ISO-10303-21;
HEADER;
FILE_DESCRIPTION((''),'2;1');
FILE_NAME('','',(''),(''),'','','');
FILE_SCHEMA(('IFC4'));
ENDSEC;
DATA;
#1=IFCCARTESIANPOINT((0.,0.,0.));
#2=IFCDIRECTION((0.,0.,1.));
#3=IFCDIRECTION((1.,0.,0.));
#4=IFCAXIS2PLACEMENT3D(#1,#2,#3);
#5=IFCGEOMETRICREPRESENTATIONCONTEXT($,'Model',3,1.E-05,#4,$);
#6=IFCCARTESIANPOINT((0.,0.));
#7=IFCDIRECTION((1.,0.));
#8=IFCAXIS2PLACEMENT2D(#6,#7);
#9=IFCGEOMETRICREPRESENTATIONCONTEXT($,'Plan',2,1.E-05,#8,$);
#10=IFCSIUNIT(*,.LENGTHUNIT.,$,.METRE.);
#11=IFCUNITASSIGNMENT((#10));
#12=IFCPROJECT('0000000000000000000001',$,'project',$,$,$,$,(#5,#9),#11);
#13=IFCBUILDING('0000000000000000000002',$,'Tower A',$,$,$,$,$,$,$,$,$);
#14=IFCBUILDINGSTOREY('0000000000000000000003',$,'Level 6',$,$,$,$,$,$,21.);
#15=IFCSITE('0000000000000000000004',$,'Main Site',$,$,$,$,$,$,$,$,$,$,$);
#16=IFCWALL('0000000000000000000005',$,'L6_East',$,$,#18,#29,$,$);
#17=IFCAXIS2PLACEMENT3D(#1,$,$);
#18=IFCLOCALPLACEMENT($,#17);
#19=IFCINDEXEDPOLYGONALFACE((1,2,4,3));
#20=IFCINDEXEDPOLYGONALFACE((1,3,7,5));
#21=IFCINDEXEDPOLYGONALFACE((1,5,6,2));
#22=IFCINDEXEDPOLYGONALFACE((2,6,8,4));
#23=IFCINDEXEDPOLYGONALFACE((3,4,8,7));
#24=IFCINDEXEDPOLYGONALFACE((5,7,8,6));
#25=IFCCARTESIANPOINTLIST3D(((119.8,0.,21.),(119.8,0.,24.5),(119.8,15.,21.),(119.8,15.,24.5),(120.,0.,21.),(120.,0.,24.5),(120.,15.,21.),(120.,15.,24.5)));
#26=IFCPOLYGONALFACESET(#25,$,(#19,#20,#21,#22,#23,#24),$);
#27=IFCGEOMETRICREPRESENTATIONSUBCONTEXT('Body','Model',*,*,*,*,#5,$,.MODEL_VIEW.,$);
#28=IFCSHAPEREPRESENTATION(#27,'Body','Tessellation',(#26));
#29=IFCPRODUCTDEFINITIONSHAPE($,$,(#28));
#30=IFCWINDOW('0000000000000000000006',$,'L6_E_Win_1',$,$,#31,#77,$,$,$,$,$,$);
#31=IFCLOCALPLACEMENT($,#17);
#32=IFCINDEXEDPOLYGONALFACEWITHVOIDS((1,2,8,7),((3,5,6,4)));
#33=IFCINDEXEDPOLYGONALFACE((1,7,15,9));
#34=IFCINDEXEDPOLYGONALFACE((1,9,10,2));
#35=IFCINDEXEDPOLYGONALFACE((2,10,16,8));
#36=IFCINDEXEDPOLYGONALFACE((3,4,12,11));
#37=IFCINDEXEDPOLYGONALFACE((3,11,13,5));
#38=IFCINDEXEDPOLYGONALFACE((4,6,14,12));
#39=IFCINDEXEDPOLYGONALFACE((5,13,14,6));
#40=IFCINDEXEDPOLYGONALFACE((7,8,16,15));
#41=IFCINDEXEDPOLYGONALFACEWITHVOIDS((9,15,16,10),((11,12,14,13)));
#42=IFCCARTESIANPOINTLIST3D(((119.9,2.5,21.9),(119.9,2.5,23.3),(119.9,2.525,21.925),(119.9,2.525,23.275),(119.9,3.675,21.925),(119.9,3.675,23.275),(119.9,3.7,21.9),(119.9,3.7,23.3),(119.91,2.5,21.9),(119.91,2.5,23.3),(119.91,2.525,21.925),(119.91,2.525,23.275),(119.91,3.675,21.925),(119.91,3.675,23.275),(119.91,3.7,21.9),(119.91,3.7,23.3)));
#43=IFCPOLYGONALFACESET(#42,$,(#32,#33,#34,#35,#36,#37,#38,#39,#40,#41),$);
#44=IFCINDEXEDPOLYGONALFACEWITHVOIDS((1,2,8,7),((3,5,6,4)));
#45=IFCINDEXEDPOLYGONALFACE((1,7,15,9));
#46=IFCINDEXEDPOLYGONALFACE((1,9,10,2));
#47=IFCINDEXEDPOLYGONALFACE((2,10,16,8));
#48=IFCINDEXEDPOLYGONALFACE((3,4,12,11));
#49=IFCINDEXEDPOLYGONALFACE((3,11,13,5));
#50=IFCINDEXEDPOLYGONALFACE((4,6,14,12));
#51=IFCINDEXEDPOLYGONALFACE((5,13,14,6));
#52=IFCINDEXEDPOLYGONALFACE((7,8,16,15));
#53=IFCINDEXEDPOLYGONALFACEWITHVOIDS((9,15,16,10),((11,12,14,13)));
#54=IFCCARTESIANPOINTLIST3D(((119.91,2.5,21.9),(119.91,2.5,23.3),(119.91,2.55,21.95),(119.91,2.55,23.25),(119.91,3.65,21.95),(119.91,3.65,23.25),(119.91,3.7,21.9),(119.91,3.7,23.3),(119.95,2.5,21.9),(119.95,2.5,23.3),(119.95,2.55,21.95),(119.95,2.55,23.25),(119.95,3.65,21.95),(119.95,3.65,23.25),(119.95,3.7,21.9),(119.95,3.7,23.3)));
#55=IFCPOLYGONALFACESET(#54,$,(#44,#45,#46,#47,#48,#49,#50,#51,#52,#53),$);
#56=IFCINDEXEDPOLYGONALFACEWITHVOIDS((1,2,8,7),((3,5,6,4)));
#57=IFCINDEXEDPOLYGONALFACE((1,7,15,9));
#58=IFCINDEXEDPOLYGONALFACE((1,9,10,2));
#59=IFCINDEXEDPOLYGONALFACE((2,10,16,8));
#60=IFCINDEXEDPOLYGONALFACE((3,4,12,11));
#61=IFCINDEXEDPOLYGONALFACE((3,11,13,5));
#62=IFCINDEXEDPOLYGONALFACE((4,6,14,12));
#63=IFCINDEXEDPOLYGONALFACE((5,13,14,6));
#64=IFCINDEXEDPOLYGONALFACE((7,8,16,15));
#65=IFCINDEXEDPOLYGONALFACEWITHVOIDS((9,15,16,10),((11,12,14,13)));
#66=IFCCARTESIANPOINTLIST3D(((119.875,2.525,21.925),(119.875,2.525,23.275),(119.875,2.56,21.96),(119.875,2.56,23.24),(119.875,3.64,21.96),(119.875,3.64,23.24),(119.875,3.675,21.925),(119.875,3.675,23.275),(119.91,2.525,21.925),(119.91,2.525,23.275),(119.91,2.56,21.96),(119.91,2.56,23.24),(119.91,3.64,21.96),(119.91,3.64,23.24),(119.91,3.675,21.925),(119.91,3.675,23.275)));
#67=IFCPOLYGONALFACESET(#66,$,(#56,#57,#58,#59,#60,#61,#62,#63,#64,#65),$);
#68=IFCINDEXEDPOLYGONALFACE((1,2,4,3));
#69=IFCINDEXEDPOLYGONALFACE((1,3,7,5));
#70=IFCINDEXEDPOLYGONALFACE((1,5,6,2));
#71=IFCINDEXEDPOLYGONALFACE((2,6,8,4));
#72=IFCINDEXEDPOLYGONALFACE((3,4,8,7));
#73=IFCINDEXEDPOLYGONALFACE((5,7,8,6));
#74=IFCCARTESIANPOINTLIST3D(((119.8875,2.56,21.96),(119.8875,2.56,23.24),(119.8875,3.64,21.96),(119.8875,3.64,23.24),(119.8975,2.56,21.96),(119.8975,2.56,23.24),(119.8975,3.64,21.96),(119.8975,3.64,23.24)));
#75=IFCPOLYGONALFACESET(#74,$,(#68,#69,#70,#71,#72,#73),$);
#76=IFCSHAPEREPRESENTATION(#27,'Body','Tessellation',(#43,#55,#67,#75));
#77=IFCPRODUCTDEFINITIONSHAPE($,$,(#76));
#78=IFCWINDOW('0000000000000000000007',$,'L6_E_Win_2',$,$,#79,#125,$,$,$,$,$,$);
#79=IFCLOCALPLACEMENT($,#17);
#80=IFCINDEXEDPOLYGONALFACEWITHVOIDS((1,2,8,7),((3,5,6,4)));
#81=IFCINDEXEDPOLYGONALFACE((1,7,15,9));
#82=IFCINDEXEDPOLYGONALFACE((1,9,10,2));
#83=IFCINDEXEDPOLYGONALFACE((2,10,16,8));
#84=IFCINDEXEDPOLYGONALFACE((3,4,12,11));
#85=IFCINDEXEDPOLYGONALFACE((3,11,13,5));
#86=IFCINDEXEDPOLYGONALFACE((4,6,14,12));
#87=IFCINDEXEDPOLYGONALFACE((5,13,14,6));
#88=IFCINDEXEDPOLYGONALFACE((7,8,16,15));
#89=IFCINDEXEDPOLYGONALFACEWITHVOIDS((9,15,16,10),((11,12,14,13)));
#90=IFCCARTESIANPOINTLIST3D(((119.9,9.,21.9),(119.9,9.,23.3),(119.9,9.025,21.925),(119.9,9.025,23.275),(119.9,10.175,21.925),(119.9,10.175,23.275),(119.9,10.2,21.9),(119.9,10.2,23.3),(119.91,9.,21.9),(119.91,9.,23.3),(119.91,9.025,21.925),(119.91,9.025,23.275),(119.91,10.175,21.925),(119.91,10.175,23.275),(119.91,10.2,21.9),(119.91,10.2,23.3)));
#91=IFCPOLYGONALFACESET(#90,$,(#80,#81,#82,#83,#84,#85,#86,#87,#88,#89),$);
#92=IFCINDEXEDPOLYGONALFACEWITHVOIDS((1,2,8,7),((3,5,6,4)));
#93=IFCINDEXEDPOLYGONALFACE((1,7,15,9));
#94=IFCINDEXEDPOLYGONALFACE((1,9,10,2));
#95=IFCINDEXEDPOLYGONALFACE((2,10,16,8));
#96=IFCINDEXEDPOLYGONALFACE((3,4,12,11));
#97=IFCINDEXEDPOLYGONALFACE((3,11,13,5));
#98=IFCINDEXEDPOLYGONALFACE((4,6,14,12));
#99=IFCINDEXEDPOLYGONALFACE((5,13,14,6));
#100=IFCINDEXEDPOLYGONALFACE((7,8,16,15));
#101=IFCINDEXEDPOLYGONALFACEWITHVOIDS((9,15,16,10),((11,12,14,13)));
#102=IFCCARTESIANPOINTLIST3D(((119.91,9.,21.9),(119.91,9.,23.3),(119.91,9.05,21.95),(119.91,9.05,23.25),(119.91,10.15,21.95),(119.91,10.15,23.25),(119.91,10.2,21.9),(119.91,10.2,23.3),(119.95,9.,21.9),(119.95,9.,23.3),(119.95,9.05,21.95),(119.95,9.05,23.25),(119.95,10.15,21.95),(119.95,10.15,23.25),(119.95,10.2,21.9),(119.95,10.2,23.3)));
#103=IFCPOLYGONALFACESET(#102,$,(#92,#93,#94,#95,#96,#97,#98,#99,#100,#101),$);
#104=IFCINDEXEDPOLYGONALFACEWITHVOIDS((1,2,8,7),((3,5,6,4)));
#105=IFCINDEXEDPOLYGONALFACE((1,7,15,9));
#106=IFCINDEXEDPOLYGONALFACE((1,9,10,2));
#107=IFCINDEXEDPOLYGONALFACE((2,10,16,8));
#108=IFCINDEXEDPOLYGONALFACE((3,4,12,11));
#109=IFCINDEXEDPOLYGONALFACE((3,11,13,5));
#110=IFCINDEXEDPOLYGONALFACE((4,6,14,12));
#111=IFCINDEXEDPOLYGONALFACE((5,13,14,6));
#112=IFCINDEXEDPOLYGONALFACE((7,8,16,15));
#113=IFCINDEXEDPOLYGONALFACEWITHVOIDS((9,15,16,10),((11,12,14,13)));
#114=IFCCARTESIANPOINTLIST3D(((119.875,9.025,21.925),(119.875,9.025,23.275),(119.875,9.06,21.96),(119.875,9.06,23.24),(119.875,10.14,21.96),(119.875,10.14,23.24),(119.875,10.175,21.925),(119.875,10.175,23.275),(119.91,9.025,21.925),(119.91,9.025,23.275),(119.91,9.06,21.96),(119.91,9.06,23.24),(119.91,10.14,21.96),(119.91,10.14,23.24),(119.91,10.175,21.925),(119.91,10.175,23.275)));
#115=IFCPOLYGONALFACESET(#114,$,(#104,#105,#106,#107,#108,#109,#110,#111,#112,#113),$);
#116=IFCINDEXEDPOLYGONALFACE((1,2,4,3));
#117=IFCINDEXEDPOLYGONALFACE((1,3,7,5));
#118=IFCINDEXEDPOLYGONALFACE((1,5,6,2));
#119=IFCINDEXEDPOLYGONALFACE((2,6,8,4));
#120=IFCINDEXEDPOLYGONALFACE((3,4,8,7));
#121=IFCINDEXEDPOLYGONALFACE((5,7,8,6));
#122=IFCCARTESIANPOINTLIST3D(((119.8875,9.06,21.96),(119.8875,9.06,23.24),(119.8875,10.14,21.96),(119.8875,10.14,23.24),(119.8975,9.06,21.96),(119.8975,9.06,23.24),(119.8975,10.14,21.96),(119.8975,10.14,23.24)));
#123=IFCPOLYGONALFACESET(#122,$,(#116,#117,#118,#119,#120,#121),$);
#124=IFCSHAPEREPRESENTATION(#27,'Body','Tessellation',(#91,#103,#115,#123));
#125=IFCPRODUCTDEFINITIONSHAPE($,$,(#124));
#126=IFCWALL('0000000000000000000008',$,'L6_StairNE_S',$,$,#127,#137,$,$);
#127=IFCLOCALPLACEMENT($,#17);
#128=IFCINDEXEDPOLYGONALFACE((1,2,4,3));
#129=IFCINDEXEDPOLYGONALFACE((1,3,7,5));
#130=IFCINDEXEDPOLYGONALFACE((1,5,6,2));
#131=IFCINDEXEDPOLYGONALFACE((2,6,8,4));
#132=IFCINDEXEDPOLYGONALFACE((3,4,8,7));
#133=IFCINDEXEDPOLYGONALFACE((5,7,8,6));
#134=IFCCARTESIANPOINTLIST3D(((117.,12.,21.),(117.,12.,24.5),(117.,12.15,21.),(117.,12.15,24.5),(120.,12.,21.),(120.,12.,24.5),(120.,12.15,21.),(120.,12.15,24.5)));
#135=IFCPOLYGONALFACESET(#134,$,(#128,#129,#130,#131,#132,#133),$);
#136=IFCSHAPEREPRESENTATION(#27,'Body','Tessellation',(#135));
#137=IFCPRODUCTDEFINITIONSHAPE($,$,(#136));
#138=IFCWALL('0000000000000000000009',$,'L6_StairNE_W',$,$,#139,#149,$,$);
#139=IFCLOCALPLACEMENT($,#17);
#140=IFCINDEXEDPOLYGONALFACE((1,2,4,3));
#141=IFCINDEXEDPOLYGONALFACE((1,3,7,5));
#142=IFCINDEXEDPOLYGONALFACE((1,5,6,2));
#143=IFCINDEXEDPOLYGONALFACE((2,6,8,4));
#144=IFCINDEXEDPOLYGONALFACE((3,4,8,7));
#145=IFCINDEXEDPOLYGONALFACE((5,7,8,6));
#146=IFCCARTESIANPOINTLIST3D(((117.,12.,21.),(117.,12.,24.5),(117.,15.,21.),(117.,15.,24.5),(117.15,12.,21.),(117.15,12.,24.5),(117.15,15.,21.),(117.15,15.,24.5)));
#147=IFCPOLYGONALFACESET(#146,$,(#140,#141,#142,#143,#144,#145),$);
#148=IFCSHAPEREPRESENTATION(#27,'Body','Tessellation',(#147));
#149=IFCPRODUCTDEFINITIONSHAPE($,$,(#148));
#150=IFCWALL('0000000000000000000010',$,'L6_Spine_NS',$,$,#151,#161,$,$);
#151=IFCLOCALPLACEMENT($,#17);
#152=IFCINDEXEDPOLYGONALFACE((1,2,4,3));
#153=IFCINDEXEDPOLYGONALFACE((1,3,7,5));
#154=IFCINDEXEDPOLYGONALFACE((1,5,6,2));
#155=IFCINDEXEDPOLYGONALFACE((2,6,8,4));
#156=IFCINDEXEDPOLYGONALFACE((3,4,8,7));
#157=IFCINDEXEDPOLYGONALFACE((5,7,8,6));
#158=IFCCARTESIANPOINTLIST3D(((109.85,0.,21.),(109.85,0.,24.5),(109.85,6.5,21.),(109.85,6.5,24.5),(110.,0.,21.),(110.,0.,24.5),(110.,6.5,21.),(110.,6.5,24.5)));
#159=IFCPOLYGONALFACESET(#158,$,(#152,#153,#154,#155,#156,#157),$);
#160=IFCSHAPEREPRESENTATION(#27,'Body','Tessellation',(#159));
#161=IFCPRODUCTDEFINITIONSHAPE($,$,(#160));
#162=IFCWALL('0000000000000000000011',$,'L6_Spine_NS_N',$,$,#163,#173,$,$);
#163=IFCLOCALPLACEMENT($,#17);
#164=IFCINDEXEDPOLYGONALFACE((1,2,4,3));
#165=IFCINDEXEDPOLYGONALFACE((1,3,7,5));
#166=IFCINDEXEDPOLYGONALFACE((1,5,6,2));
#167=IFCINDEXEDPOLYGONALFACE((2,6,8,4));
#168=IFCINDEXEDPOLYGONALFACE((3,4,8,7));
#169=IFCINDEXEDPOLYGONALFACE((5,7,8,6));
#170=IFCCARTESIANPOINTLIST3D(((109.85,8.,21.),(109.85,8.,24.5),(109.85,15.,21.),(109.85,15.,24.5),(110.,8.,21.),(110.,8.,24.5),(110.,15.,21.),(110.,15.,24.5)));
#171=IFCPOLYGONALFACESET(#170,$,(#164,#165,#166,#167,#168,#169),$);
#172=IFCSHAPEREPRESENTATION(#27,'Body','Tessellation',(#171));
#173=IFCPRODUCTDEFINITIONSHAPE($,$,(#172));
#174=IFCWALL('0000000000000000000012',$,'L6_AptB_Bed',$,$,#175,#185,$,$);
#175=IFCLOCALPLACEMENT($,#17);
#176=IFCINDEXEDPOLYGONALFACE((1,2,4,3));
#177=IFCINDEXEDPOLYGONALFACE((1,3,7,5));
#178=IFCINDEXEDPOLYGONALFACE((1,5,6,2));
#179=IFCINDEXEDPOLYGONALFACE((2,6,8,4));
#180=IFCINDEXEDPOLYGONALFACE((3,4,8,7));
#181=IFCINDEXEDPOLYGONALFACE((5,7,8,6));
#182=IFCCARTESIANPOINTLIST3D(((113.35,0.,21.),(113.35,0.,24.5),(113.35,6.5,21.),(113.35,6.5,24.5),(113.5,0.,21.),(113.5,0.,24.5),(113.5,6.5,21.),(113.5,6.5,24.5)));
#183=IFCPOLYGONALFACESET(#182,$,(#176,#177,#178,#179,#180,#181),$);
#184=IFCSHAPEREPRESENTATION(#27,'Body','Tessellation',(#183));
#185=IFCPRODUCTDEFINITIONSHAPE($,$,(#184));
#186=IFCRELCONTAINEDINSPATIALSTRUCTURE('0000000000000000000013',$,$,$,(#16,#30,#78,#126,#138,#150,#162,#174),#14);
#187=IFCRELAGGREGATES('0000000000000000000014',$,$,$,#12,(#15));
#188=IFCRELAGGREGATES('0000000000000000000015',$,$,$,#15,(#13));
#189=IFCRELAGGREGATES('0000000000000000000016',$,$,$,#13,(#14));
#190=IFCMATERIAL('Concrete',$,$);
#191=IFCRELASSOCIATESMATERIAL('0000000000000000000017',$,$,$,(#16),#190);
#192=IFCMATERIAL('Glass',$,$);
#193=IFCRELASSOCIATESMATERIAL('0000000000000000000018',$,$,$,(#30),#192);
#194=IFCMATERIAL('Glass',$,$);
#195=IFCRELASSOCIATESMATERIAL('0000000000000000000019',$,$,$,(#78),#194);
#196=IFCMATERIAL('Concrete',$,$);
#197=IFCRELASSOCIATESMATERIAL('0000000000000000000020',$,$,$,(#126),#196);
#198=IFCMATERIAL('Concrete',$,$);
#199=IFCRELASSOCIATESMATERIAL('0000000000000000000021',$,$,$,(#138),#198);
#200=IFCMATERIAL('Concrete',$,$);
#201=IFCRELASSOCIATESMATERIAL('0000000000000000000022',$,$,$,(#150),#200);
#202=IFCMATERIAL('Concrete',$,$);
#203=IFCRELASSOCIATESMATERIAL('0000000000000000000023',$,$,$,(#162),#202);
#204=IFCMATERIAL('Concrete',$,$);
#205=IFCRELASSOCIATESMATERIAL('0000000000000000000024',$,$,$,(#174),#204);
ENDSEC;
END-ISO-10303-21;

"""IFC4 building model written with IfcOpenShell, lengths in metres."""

from ifc_helpers import new_model, si_unit, frame, origin_with_axes, origin_2d_with_axis, place, context, subcontext, project, spatial, line, indexed_curve, outline, extrude, material, element, fill, save


model = new_model("IFC4")

# Units and contexts
model_context = context("Model", 3, precision=1e-05, world=origin_with_axes())
plan_context = context("Plan", 2, precision=1e-05, world=origin_2d_with_axis())
body_context = subcontext(model_context, "Body", "Model", "MODEL_VIEW")
ifc_project = project(units=[si_unit("LENGTHUNIT", "METRE")], contexts=[model_context, plan_context])

# Site, building, storey
site = spatial("IfcSite", under=ifc_project, Name="Main Site")
building = spatial("IfcBuilding", under=site, Name="Tower A")
storey = spatial("IfcBuildingStorey", under=building, Name="Level 6", Elevation=21.0)

# Wall, openings, windows
ifc_material_1 = material(Name="Concrete")
wall_1_placement = place(None, frame((120.0, 0.0, 21.0), z_axis=(0.0, 0.0, 1.0), x_axis=(0.0, 1.0, 0.0)))
wall_1 = element("IfcWall", 1, at=wall_1_placement, inside=storey, material=ifc_material_1, Name="L6_East", context=body_context, shape_type="SweptSolid", body=[
    extrude(outline(indexed_curve([(0.0, 0.0), (0.0, 0.2), (15.0, 0.2), (15.0, 0.0), (0.0, 0.0)], self_intersect=False)), origin_with_axes(), (0.0, 0.0, 1.0), 3.5),
])
opening_1_placement = place(wall_1_placement, frame((2.5, 0.0, 0.9), z_axis=(0.0, 0.0, 1.0), x_axis=(0.0, -1.0, 0.0)))
opening_1 = element("IfcOpeningElement", 2, at=opening_1_placement, cuts=wall_1, context=body_context, shape_type="SweptSolid", body=[
    extrude(outline(indexed_curve([(0.0, 0.0), (0.0, 0.25), (1.2, 0.25), (1.2, 0.0), (0.0, 0.0)], self_intersect=False)), origin_with_axes(), (0.0, 0.0, 1.0), 1.4),
])
opening_2_placement = place(wall_1_placement, frame((9.0, 0.0, 0.9), z_axis=(0.0, 0.0, 1.0), x_axis=(0.0, -1.0, 0.0)))
opening_2 = element("IfcOpeningElement", 3, at=opening_2_placement, cuts=wall_1, context=body_context, shape_type="SweptSolid", body=[
    extrude(outline(indexed_curve([(0.0, 0.0), (0.0, 0.25), (1.2, 0.25), (1.2, 0.0), (0.0, 0.0)], self_intersect=False)), origin_with_axes(), (0.0, 0.0, 1.0), 1.4),
])
ifc_material_2 = material(Name="Glass")
window_1_placement = place(None, frame((120.0, 2.5, 21.9), z_axis=(0.0, 0.0, 1.0), x_axis=(0.0, 1.0, 0.0)))
window_1 = element("IfcWindow", 4, at=window_1_placement, inside=storey, material=ifc_material_2, Name="L6_E_Win_1", context=body_context, shape_type="SweptSolid", body=[
    extrude(outline(indexed_curve([(0.0, 0.0), (1.2, 0.0), (1.2, 1.4), (0.0, 1.4)], segments=[line(1, 2, 3, 4, 1)]), holes=[indexed_curve([(0.025, 0.025), (1.175, 0.025), (1.175, 1.375), (0.025, 1.375)], segments=[line(1, 2, 3, 4, 1)])]), frame((0.0, 0.09, 0.0), z_axis=(0.0, -1.0, 0.0), x_axis=(1.0, 0.0, 0.0)), (0.0, 0.0, -1.0), 0.01),
    extrude(outline(indexed_curve([(0.0, 0.0), (1.2, 0.0), (1.2, 1.4), (0.0, 1.4)], segments=[line(1, 2, 3, 4, 1)]), holes=[indexed_curve([(0.05, 0.05), (1.15, 0.05), (1.15, 1.35), (0.05, 1.35)], segments=[line(1, 2, 3, 4, 1)])]), frame((0.0, 0.05, 0.0), z_axis=(0.0, -1.0, 0.0), x_axis=(1.0, 0.0, 0.0)), (0.0, 0.0, -1.0), 0.04),
    extrude(outline(indexed_curve([(0.0, 0.0), (1.15, 0.0), (1.15, 1.35), (0.0, 1.35)], segments=[line(1, 2, 3, 4, 1)]), holes=[indexed_curve([(0.035, 0.035), (1.115, 0.035), (1.115, 1.315), (0.035, 1.315)], segments=[line(1, 2, 3, 4, 1)])]), frame((0.025, 0.09, 0.025), z_axis=(0.0, -1.0, 0.0), x_axis=(1.0, 0.0, 0.0)), (0.0, 0.0, -1.0), 0.035),
    extrude(outline(indexed_curve([(0.035, 0.035), (1.115, 0.035), (1.115, 1.315), (0.035, 1.315)], segments=[line(1, 2, 3, 4, 1)])), frame((0.025, 0.1025, 0.025), z_axis=(0.0, -1.0, 0.0), x_axis=(1.0, 0.0, 0.0)), (0.0, 0.0, -1.0), 0.01),
])
fill(opening_1, window_1)
ifc_material_3 = material(Name="Glass")
window_2_placement = place(None, frame((120.0, 9.0, 21.9), z_axis=(0.0, 0.0, 1.0), x_axis=(0.0, 1.0, 0.0)))
window_2 = element("IfcWindow", 5, at=window_2_placement, inside=storey, material=ifc_material_3, Name="L6_E_Win_2", context=body_context, shape_type="SweptSolid", body=[
    extrude(outline(indexed_curve([(0.0, 0.0), (1.2, 0.0), (1.2, 1.4), (0.0, 1.4)], segments=[line(1, 2, 3, 4, 1)]), holes=[indexed_curve([(0.025, 0.025), (1.175, 0.025), (1.175, 1.375), (0.025, 1.375)], segments=[line(1, 2, 3, 4, 1)])]), frame((0.0, 0.09, 0.0), z_axis=(0.0, -1.0, 0.0), x_axis=(1.0, 0.0, 0.0)), (0.0, 0.0, -1.0), 0.01),
    extrude(outline(indexed_curve([(0.0, 0.0), (1.2, 0.0), (1.2, 1.4), (0.0, 1.4)], segments=[line(1, 2, 3, 4, 1)]), holes=[indexed_curve([(0.05, 0.05), (1.15, 0.05), (1.15, 1.35), (0.05, 1.35)], segments=[line(1, 2, 3, 4, 1)])]), frame((0.0, 0.05, 0.0), z_axis=(0.0, -1.0, 0.0), x_axis=(1.0, 0.0, 0.0)), (0.0, 0.0, -1.0), 0.04),
    extrude(outline(indexed_curve([(0.0, 0.0), (1.15, 0.0), (1.15, 1.35), (0.0, 1.35)], segments=[line(1, 2, 3, 4, 1)]), holes=[indexed_curve([(0.035, 0.035), (1.115, 0.035), (1.115, 1.315), (0.035, 1.315)], segments=[line(1, 2, 3, 4, 1)])]), frame((0.025, 0.09, 0.025), z_axis=(0.0, -1.0, 0.0), x_axis=(1.0, 0.0, 0.0)), (0.0, 0.0, -1.0), 0.035),
    extrude(outline(indexed_curve([(0.035, 0.035), (1.115, 0.035), (1.115, 1.315), (0.035, 1.315)], segments=[line(1, 2, 3, 4, 1)])), frame((0.025, 0.1025, 0.025), z_axis=(0.0, -1.0, 0.0), x_axis=(1.0, 0.0, 0.0)), (0.0, 0.0, -1.0), 0.01),
])
fill(opening_2, window_2)

# Walls
ifc_material_4 = material(Name="Concrete")
wall_2_placement = place(None, frame((117.0, 12.0, 21.0), z_axis=(0.0, 0.0, 1.0), x_axis=(1.0, 0.0, 0.0)))
element("IfcWall", 6, at=wall_2_placement, inside=storey, material=ifc_material_4, Name="L6_StairNE_S", context=body_context, shape_type="SweptSolid", body=[
    extrude(outline(indexed_curve([(0.0, 0.0), (0.0, 0.15), (3.0, 0.15), (3.0, 0.0), (0.0, 0.0)], self_intersect=False)), origin_with_axes(), (0.0, 0.0, 1.0), 3.5),
])
ifc_material_5 = material(Name="Concrete")
wall_3_placement = place(None, frame((117.0, 15.0, 21.0), z_axis=(0.0, 0.0, 1.0), x_axis=(0.0, -1.0, 0.0)))
element("IfcWall", 7, at=wall_3_placement, inside=storey, material=ifc_material_5, Name="L6_StairNE_W", context=body_context, shape_type="SweptSolid", body=[
    extrude(outline(indexed_curve([(0.0, 0.0), (0.0, 0.15), (3.0, 0.15), (3.0, 0.0), (0.0, 0.0)], self_intersect=False)), origin_with_axes(), (0.0, 0.0, 1.0), 3.5),
])
ifc_material_6 = material(Name="Concrete")
wall_4_placement = place(None, frame((110.0, 0.0, 21.0), z_axis=(0.0, 0.0, 1.0), x_axis=(0.0, 1.0, 0.0)))
element("IfcWall", 8, at=wall_4_placement, inside=storey, material=ifc_material_6, Name="L6_Spine_NS", context=body_context, shape_type="SweptSolid", body=[
    extrude(outline(indexed_curve([(0.0, 0.0), (0.0, 0.15), (6.5, 0.15), (6.5, 0.0), (0.0, 0.0)], self_intersect=False)), origin_with_axes(), (0.0, 0.0, 1.0), 3.5),
])
ifc_material_7 = material(Name="Concrete")
wall_5_placement = place(None, frame((110.0, 8.0, 21.0), z_axis=(0.0, 0.0, 1.0), x_axis=(0.0, 1.0, 0.0)))
element("IfcWall", 9, at=wall_5_placement, inside=storey, material=ifc_material_7, Name="L6_Spine_NS_N", context=body_context, shape_type="SweptSolid", body=[
    extrude(outline(indexed_curve([(0.0, 0.0), (0.0, 0.15), (7.0, 0.15), (7.0, 0.0), (0.0, 0.0)], self_intersect=False)), origin_with_axes(), (0.0, 0.0, 1.0), 3.5),
])
ifc_material_8 = material(Name="Concrete")
wall_6_placement = place(None, frame((113.5, 0.0, 21.0), z_axis=(0.0, 0.0, 1.0), x_axis=(0.0, 1.0, 0.0)))
element("IfcWall", 10, at=wall_6_placement, inside=storey, material=ifc_material_8, Name="L6_AptB_Bed", context=body_context, shape_type="SweptSolid", body=[
    extrude(outline(indexed_curve([(0.0, 0.0), (0.0, 0.15), (6.5, 0.15), (6.5, 0.0), (0.0, 0.0)], self_intersect=False)), origin_with_axes(), (0.0, 0.0, 1.0), 3.5),
])

save(model, "model.ifc")
